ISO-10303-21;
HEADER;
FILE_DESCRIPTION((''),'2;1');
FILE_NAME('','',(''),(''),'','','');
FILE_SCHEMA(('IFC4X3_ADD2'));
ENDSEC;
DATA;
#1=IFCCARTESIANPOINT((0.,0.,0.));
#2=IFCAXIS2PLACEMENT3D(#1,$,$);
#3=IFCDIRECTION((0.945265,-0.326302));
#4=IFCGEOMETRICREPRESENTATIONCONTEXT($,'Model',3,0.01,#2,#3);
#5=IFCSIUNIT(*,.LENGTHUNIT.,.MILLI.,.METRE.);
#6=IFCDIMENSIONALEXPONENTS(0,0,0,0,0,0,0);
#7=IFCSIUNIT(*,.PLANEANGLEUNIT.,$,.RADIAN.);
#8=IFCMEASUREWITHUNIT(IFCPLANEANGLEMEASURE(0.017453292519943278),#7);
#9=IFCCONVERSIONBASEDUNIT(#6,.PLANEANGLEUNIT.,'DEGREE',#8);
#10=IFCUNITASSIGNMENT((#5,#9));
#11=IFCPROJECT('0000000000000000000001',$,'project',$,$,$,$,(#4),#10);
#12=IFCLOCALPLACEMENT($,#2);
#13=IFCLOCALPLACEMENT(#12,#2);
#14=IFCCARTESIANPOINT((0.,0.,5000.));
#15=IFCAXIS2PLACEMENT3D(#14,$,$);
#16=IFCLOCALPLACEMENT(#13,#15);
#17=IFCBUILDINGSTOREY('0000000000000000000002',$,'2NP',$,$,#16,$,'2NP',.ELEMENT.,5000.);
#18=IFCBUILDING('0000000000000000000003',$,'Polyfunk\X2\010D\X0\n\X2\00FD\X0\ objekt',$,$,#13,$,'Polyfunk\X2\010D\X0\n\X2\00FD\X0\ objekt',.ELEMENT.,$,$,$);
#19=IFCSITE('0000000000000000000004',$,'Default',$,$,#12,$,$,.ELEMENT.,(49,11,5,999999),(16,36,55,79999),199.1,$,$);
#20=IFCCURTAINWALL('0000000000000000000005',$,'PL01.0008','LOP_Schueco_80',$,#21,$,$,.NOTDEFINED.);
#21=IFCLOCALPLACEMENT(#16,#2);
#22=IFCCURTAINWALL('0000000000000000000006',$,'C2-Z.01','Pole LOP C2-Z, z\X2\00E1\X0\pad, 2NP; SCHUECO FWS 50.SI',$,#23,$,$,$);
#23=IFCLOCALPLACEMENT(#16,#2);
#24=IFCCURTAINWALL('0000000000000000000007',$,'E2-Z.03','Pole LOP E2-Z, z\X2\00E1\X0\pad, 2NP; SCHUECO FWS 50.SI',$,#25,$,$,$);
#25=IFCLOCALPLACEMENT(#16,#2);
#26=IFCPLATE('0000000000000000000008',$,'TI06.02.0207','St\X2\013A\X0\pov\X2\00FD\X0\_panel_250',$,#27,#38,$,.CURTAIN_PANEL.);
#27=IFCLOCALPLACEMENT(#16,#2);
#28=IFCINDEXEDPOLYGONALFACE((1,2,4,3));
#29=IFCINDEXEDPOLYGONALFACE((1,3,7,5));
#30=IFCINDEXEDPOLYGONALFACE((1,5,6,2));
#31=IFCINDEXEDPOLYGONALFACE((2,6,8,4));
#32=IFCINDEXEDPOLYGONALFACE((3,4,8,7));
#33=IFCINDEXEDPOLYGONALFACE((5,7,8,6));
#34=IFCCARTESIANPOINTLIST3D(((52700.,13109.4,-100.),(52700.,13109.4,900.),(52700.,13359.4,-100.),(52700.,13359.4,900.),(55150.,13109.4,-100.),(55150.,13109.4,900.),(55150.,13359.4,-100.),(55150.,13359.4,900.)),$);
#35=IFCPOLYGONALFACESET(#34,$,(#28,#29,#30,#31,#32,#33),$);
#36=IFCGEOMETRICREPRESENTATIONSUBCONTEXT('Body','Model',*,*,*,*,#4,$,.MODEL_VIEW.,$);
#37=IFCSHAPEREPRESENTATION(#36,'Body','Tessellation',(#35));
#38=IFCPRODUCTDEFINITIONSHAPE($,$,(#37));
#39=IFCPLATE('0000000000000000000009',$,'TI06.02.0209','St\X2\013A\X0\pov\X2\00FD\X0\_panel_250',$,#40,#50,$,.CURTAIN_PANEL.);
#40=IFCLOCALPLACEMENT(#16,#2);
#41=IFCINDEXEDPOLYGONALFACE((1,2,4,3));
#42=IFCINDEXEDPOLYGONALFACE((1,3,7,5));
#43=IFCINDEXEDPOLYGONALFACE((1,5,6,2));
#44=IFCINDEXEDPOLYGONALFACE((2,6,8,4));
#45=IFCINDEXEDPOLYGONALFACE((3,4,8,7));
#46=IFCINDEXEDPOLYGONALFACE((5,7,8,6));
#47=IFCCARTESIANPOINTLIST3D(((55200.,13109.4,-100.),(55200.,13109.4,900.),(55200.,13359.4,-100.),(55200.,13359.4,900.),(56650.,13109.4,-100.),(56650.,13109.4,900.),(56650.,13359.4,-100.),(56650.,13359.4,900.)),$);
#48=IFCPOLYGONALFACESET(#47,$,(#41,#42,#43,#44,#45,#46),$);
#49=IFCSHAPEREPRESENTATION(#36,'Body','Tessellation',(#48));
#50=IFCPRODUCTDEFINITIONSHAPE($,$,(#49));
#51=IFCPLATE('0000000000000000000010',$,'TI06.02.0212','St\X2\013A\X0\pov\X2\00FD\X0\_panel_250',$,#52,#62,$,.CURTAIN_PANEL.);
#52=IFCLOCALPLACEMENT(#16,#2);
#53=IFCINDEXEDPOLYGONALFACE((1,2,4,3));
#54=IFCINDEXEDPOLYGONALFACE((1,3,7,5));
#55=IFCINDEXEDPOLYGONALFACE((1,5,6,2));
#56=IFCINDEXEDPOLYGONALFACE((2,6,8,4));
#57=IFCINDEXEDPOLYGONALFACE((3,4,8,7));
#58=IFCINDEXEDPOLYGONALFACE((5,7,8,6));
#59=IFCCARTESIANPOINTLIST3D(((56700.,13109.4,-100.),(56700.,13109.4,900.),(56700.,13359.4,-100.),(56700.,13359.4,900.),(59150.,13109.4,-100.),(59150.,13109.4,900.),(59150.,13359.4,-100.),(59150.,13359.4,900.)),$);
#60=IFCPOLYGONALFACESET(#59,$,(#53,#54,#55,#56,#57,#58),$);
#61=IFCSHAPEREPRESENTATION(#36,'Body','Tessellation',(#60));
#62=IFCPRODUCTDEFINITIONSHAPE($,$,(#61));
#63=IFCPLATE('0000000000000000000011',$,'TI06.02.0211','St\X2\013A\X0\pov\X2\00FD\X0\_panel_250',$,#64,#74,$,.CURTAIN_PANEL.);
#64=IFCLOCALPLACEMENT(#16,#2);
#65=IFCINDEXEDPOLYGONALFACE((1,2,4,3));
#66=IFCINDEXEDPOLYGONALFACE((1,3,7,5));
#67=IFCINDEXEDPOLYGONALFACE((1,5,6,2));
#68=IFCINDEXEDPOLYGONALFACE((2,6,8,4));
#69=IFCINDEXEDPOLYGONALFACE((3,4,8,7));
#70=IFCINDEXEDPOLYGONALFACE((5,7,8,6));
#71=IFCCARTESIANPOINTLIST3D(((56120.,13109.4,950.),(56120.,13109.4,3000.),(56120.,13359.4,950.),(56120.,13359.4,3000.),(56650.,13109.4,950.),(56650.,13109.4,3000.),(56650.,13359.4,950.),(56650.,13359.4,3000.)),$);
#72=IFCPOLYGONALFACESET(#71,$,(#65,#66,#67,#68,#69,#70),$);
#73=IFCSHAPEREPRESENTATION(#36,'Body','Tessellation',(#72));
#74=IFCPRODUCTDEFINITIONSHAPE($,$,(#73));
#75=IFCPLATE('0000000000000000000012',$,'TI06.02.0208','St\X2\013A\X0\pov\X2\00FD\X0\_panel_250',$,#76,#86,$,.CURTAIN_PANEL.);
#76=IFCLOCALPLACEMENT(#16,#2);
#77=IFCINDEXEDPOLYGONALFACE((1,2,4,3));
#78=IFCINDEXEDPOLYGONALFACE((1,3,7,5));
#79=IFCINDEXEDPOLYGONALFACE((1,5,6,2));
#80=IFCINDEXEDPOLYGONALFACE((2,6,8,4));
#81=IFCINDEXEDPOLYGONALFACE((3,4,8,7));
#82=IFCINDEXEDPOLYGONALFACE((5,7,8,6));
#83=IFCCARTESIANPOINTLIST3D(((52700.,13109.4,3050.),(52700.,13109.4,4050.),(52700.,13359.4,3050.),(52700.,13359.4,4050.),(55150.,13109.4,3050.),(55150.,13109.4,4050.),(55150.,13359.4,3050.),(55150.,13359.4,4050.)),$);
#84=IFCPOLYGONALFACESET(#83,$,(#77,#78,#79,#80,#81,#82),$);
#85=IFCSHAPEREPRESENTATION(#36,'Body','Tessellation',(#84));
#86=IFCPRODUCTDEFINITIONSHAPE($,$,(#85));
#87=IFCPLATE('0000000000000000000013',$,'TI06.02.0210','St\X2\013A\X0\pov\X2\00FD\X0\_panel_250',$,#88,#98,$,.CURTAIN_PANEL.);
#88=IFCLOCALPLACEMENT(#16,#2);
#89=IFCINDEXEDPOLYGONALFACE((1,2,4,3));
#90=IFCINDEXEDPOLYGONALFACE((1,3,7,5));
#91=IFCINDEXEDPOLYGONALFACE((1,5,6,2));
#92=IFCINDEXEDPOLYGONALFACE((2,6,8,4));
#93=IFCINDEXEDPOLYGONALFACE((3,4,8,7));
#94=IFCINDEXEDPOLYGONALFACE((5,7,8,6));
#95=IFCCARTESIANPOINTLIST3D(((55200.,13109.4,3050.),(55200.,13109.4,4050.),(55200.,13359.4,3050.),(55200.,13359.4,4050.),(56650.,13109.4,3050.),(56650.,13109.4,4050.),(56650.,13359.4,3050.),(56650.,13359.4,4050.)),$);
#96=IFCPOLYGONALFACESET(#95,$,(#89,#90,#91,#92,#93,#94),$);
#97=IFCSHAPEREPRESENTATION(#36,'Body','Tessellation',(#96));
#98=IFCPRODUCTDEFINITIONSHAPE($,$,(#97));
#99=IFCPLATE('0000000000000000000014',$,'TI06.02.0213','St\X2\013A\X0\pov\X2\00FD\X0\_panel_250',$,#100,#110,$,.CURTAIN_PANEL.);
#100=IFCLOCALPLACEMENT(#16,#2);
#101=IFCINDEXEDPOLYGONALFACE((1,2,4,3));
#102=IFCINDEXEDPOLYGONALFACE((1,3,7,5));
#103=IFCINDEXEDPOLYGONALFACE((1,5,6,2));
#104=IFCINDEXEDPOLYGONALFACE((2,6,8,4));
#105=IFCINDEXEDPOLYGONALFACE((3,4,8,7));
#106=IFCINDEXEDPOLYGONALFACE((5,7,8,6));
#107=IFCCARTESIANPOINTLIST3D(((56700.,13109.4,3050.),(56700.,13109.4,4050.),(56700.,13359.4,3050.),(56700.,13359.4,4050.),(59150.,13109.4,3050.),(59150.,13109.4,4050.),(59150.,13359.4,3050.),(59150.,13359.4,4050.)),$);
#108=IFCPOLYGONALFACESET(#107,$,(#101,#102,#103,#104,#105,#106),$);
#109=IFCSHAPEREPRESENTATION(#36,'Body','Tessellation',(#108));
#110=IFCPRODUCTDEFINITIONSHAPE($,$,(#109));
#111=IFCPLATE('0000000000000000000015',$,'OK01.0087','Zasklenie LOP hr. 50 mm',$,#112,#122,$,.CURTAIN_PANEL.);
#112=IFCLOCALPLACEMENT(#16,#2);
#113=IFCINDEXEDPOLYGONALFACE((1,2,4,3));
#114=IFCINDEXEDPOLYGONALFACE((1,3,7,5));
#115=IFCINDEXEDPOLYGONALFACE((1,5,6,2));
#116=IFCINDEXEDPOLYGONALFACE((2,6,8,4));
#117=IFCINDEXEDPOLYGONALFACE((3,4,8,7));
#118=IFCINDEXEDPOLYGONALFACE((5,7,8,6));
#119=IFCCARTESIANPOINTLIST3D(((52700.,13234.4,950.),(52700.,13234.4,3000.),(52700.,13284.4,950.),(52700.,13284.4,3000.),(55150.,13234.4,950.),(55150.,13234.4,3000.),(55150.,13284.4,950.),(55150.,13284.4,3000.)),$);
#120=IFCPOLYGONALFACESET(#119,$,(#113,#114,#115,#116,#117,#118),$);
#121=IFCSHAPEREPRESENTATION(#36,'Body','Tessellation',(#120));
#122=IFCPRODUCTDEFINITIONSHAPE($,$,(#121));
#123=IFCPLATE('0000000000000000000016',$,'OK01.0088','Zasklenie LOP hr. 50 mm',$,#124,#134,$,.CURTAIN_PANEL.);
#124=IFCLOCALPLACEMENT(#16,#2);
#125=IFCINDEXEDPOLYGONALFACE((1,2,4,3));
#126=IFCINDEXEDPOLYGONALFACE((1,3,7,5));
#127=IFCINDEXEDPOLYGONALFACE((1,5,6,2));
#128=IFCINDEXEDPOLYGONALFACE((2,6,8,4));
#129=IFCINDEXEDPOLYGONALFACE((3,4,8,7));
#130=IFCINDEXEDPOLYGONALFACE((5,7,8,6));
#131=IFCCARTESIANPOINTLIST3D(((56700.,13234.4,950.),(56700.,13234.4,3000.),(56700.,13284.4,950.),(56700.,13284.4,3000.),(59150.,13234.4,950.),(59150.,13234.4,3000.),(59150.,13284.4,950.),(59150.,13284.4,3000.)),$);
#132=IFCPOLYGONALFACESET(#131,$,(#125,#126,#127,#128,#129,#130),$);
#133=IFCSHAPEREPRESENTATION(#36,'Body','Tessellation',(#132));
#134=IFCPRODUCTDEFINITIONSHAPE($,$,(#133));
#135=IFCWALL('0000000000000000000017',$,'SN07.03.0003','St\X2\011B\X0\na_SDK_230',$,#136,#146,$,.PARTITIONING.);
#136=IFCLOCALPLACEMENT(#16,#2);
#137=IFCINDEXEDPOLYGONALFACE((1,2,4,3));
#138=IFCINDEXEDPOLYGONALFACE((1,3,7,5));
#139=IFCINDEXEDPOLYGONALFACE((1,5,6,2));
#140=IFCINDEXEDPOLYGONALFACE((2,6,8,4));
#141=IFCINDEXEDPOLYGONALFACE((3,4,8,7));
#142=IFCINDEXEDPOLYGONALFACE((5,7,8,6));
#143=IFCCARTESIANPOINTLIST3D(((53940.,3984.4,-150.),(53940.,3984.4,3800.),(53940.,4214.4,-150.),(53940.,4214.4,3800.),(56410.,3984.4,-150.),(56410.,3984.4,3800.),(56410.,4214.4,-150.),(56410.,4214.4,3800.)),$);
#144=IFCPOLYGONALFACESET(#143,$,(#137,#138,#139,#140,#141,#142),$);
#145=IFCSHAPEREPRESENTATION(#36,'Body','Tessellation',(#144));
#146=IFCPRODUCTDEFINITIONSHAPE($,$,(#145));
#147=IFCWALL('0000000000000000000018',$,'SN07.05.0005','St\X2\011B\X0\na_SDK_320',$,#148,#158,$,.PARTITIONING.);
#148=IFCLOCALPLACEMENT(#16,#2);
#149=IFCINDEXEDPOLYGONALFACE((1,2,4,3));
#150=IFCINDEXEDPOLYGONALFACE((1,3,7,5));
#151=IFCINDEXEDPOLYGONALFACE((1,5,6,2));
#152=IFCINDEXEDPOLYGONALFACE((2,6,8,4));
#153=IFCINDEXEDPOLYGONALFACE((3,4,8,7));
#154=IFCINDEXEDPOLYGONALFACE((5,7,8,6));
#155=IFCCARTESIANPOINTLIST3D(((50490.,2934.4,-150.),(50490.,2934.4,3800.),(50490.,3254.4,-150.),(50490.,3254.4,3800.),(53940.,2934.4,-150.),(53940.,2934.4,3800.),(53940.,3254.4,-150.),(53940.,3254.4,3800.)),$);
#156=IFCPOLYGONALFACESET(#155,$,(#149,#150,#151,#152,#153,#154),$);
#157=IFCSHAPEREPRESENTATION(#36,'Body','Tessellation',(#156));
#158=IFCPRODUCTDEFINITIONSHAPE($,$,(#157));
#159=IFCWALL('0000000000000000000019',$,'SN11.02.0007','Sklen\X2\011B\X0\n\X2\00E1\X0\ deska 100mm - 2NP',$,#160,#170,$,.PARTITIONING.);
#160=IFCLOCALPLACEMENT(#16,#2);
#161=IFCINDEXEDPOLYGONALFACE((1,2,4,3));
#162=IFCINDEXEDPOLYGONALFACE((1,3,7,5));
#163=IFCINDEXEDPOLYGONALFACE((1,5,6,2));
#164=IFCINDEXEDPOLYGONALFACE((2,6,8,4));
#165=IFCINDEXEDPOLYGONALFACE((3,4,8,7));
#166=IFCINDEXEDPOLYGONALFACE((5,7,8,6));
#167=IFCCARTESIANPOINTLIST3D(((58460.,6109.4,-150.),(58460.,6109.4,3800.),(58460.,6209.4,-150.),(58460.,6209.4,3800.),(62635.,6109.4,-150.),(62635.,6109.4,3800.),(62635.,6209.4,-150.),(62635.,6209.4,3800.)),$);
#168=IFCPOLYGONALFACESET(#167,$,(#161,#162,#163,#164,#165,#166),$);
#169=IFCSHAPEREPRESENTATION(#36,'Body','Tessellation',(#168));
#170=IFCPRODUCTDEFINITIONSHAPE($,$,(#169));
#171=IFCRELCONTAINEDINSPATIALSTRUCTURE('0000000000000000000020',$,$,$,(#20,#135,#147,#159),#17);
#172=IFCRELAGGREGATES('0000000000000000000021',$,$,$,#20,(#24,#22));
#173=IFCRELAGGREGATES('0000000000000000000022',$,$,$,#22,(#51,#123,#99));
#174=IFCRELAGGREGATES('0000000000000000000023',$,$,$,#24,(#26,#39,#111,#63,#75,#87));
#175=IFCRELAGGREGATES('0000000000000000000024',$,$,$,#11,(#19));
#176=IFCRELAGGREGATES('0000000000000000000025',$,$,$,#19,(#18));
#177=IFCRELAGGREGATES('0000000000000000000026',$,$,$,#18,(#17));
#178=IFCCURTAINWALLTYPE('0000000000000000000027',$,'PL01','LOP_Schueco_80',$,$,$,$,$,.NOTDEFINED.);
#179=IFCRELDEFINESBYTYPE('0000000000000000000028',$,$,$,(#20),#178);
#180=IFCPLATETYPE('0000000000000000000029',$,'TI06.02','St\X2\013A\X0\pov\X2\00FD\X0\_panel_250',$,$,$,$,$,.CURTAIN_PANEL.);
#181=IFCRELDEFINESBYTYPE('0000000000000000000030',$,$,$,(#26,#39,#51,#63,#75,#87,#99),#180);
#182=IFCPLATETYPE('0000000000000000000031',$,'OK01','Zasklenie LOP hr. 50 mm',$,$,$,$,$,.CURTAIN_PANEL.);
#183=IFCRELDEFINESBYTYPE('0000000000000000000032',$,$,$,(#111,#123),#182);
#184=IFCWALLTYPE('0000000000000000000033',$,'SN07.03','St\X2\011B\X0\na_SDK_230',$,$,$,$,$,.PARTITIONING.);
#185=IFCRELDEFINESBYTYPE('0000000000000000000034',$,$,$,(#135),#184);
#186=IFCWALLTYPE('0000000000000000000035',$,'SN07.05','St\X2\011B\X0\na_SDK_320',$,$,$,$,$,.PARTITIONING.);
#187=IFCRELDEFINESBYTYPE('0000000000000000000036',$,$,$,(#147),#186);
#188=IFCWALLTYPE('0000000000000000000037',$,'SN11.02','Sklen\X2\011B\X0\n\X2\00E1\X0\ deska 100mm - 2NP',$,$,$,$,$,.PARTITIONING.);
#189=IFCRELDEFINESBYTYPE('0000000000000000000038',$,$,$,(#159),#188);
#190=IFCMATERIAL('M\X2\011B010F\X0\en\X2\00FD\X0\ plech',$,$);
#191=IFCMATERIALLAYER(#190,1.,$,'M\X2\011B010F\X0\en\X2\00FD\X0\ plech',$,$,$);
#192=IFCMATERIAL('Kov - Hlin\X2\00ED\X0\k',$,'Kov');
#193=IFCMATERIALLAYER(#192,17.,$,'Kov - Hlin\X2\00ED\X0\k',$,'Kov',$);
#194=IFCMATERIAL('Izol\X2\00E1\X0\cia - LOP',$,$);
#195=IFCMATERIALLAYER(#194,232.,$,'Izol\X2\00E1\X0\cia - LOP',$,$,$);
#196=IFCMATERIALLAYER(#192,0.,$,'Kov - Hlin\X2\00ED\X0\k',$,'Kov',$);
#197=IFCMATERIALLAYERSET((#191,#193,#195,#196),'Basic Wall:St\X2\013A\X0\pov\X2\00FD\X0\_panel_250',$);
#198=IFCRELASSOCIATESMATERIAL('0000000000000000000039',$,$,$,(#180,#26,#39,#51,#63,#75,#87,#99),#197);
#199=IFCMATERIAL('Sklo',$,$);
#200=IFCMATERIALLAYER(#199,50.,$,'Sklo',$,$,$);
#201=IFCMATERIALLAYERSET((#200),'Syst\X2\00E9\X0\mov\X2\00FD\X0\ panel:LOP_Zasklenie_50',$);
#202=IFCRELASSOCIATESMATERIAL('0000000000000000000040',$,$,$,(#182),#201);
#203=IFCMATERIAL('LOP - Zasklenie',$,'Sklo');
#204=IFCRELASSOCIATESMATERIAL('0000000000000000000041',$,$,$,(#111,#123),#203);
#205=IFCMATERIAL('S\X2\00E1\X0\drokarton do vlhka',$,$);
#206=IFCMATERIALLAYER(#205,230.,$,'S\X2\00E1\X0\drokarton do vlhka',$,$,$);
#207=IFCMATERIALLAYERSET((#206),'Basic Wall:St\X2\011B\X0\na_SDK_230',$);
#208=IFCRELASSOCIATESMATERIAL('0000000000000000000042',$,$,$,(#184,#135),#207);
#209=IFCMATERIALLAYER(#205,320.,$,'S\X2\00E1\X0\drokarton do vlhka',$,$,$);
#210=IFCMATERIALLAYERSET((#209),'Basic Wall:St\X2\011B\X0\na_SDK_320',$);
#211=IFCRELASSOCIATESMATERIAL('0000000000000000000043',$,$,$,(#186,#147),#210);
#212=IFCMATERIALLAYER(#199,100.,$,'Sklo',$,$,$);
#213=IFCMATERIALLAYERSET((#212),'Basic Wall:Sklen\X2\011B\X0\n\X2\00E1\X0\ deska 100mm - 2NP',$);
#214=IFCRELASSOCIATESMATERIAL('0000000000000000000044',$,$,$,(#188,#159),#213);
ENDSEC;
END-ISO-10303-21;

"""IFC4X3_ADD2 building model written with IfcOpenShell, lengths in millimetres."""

from ifc_helpers import new_model, entity, si_unit, converted_unit, direction, frame, frame_2d, origin, origin_2d_with_axis, place, context, subcontext, project, spatial, polyline, rectangle, extrude, clip, bounded_halfspace, source, transform, mapped, material, layer, layer_set, layer_usage, type_object, type_shapes, element, aggregate, save


model = new_model("IFC4X3_ADD2")

# Units and contexts
model_context = context("Model", 3, precision=0.01, world=origin(), true_north=direction((0.945265, -0.326302)))
body_context = subcontext(model_context, "Body", "Model", "MODEL_VIEW")
ifc_project = project(units=[si_unit("LENGTHUNIT", "METRE", prefix="MILLI"), converted_unit("PLANEANGLEUNIT", "DEGREE", entity("IfcPlaneAngleMeasure", 0.017453292519943278), si_unit("PLANEANGLEUNIT", "RADIAN"), dimensions=[0, 0, 0, 0, 0, 0, 0])], contexts=[model_context])

# Site, building, storey
site_placement = place(None, origin())
site = spatial("IfcSite", under=ifc_project, at=site_placement, Name="Default", CompositionType="ELEMENT", RefLatitude=(49, 11, 5, 999999), RefLongitude=(16, 36, 55, 79999), RefElevation=199.1)
building_placement = place(site_placement, origin())
building = spatial("IfcBuilding", under=site, at=building_placement, Name="Polyfunkčný objekt", LongName="Polyfunkčný objekt", CompositionType="ELEMENT")
storey_placement = place(building_placement, frame((0.0, 0.0, 5000.0)))
storey = spatial("IfcBuildingStorey", under=building, at=storey_placement, Name="2NP", LongName="2NP", CompositionType="ELEMENT", Elevation=5000.0)

# Curtain walls, plates
curtain_wall_type = type_object("IfcCurtainWallType", Name="PL01", Description="LOP_Schueco_80", PredefinedType="NOTDEFINED")
curtain_wall_1_placement = place(storey_placement, frame((0.0, 0.0, -5000.0)))
curtain_wall_1 = element("IfcCurtainWall", 1, at=curtain_wall_1_placement, inside=storey, type_object=curtain_wall_type, Name="PL01.0008", Description="LOP_Schueco_80", PredefinedType="NOTDEFINED")
curtain_wall_2 = element("IfcCurtainWall", 2, Name="C2-Z.01", Description="Pole LOP C2-Z, západ, 2NP; SCHUECO FWS 50.SI")
curtain_wall_3 = element("IfcCurtainWall", 3, Name="E2-Z.03", Description="Pole LOP E2-Z, západ, 2NP; SCHUECO FWS 50.SI")
aggregate(curtain_wall_1, [curtain_wall_3, curtain_wall_2])
ifc_material_1 = material(Name="Měďený plech")
ifc_layer_1 = layer(ifc_material_1, 1.0, Name="Měďený plech")
ifc_material_2 = material(Name="Kov - Hliník", Category="Kov")
ifc_layer_2 = layer(ifc_material_2, 17.0, Name="Kov - Hliník", Category="Kov")
ifc_material_3 = material(Name="Izolácia - LOP")
ifc_layer_3 = layer(ifc_material_3, 232.0, Name="Izolácia - LOP")
ifc_layer_4 = layer(ifc_material_2, 0.0, Name="Kov - Hliník", Category="Kov")
ifc_layer_set_1 = layer_set([ifc_layer_1, ifc_layer_2, ifc_layer_3, ifc_layer_4], Name="Basic Wall:Stĺpový_panel_250")
ifc_layer_usage_1 = layer_usage(ifc_layer_set_1, "AXIS2", "NEGATIVE", 125.0)
plate_type_1 = type_object("IfcPlateType", Name="TI06.02", Description="Stĺpový_panel_250", PredefinedType="CURTAIN_PANEL", material=ifc_layer_set_1)
plate_1_placement = place(storey_placement, frame((52700.0, 13234.4, -100.0)))
plate_1 = element("IfcPlate", 4, at=plate_1_placement, type_object=plate_type_1, material=ifc_layer_usage_1, Name="TI06.02.0207", Description="Stĺpový_panel_250", PredefinedType="CURTAIN_PANEL", context=body_context, shape_type="SweptSolid", body=[
    extrude(rectangle(XDim=250.0, YDim=2450.0, at=origin_2d_with_axis()), frame((1225.0, 0.0, 0.0), z_axis=(0.0, 0.0, 1.0), x_axis=(0.0, 1.0, 0.0)), (0.0, 0.0, 1.0), 1000.0),
])
ifc_layer_usage_2 = layer_usage(ifc_layer_set_1, "AXIS2", "NEGATIVE", 125.0)
plate_2_placement = place(storey_placement, frame((55200.0, 13234.4, -100.0)))
plate_2 = element("IfcPlate", 5, at=plate_2_placement, type_object=plate_type_1, material=ifc_layer_usage_2, Name="TI06.02.0209", Description="Stĺpový_panel_250", PredefinedType="CURTAIN_PANEL", context=body_context, shape_type="SweptSolid", body=[
    extrude(rectangle(XDim=250.0, YDim=1450.0, at=origin_2d_with_axis()), frame((725.0, 0.0, 0.0), z_axis=(0.0, 0.0, 1.0), x_axis=(0.0, 1.0, 0.0)), (0.0, 0.0, 1.0), 1000.0),
])
ifc_layer_usage_3 = layer_usage(ifc_layer_set_1, "AXIS2", "NEGATIVE", 125.0)
plate_3_placement = place(storey_placement, frame((56700.0, 13234.4, -100.0)))
plate_3 = element("IfcPlate", 6, at=plate_3_placement, type_object=plate_type_1, material=ifc_layer_usage_3, Name="TI06.02.0212", Description="Stĺpový_panel_250", PredefinedType="CURTAIN_PANEL", context=body_context, shape_type="SweptSolid", body=[
    extrude(rectangle(XDim=250.0, YDim=2450.0, at=frame_2d((0.0, 0.0), x_axis=(1.0, 0.0))), frame((1225.0, 0.0, 0.0), z_axis=(0.0, 0.0, 1.0), x_axis=(0.0, 1.0, 0.0)), (0.0, 0.0, 1.0), 1000.0),
])
ifc_layer_usage_4 = layer_usage(ifc_layer_set_1, "AXIS2", "NEGATIVE", 125.0)
plate_4_placement = place(storey_placement, frame((56120.0, 13234.4, 950.0)))
plate_4 = element("IfcPlate", 7, at=plate_4_placement, type_object=plate_type_1, material=ifc_layer_usage_4, Name="TI06.02.0211", Description="Stĺpový_panel_250", PredefinedType="CURTAIN_PANEL", context=body_context, shape_type="SweptSolid", body=[
    extrude(rectangle(XDim=250.0, YDim=530.0, at=frame_2d((0.0, 0.0), x_axis=(1.0, 0.0))), frame((265.0, 0.0, 0.0), z_axis=(0.0, 0.0, 1.0), x_axis=(0.0, 1.0, 0.0)), (0.0, 0.0, 1.0), 2050.0),
])
ifc_layer_usage_5 = layer_usage(ifc_layer_set_1, "AXIS2", "NEGATIVE", 125.0)
plate_5_placement = place(storey_placement, frame((52700.0, 13234.4, 3050.0)))
plate_5 = element("IfcPlate", 8, at=plate_5_placement, type_object=plate_type_1, material=ifc_layer_usage_5, Name="TI06.02.0208", Description="Stĺpový_panel_250", PredefinedType="CURTAIN_PANEL", context=body_context, shape_type="SweptSolid", body=[
    extrude(rectangle(XDim=250.0, YDim=2450.0, at=origin_2d_with_axis()), frame((1225.0, 0.0, 0.0), z_axis=(0.0, 0.0, 1.0), x_axis=(0.0, 1.0, 0.0)), (0.0, 0.0, 1.0), 1000.0),
])
ifc_layer_usage_6 = layer_usage(ifc_layer_set_1, "AXIS2", "NEGATIVE", 125.0)
plate_6_placement = place(storey_placement, frame((55200.0, 13234.4, 3050.0)))
plate_6 = element("IfcPlate", 9, at=plate_6_placement, type_object=plate_type_1, material=ifc_layer_usage_6, Name="TI06.02.0210", Description="Stĺpový_panel_250", PredefinedType="CURTAIN_PANEL", context=body_context, shape_type="SweptSolid", body=[
    extrude(rectangle(XDim=250.0, YDim=1450.0, at=origin_2d_with_axis()), frame((725.0, 0.0, 0.0), z_axis=(0.0, 0.0, 1.0), x_axis=(0.0, 1.0, 0.0)), (0.0, 0.0, 1.0), 1000.0),
])
ifc_layer_usage_7 = layer_usage(ifc_layer_set_1, "AXIS2", "NEGATIVE", 125.0)
plate_7_placement = place(storey_placement, frame((56700.0, 13234.4, 3050.0)))
plate_7 = element("IfcPlate", 10, at=plate_7_placement, type_object=plate_type_1, material=ifc_layer_usage_7, Name="TI06.02.0213", Description="Stĺpový_panel_250", PredefinedType="CURTAIN_PANEL", context=body_context, shape_type="SweptSolid", body=[
    extrude(rectangle(XDim=250.0, YDim=2450.0, at=frame_2d((0.0, 0.0), x_axis=(1.0, 0.0))), frame((1225.0, 0.0, 0.0), z_axis=(0.0, 0.0, 1.0), x_axis=(0.0, 1.0, 0.0)), (0.0, 0.0, 1.0), 1000.0),
])
ifc_material_4 = material(Name="LOP - Zasklenie", Category="Sklo")
ifc_material_5 = material(Name="Sklo")
ifc_layer_5 = layer(ifc_material_5, 50.0, Name="Sklo")
ifc_layer_set_2 = layer_set([ifc_layer_5], Name="Systémový panel:LOP_Zasklenie_50")
plate_type_2 = type_object("IfcPlateType", Name="OK01", Description="Zasklenie LOP hr. 50 mm", PredefinedType="CURTAIN_PANEL", material=ifc_layer_set_2)
shared_shape_1 = source(origin(), body_context, "Body", "SweptSolid", [
    extrude(rectangle(XDim=50.0, YDim=2450.0, at=origin_2d_with_axis()), frame((0.0, 25.0, 0.0), z_axis=(0.0, 0.0, 1.0), x_axis=(0.0, 1.0, 0.0)), (0.0, 0.0, 1.0), 2050.0),
])
type_shapes(plate_type_2, [shared_shape_1])
plate_8_placement = place(curtain_wall_1_placement, frame((53925.0, 13234.4, 5950.0)))
plate_8 = element("IfcPlate", 11, at=plate_8_placement, type_object=plate_type_2, material=ifc_material_4, Name="OK01.0087", Description="Zasklenie LOP hr. 50 mm", PredefinedType="CURTAIN_PANEL", context=body_context, shape_type="MappedRepresentation", body=[
    mapped(shared_shape_1, transform((0.0, 0.0, 0.0), scale=1.0)),
])
plate_9_placement = place(curtain_wall_1_placement, frame((57925.0, 13234.4, 5950.0)))
plate_9 = element("IfcPlate", 12, at=plate_9_placement, type_object=plate_type_2, material=ifc_material_4, Name="OK01.0088", Description="Zasklenie LOP hr. 50 mm", PredefinedType="CURTAIN_PANEL", context=body_context, shape_type="MappedRepresentation", body=[
    mapped(shared_shape_1, transform((0.0, 0.0, 0.0), scale=1.0)),
])
aggregate(curtain_wall_2, [plate_3, plate_9, plate_7])

# Walls
ifc_material_6 = material(Name="Sádrokarton do vlhka")
ifc_layer_6 = layer(ifc_material_6, 230.0, Name="Sádrokarton do vlhka")
ifc_layer_set_3 = layer_set([ifc_layer_6], Name="Basic Wall:Stěna_SDK_230")
wall_type_1 = type_object("IfcWallType", Name="SN07.03", Description="Stěna_SDK_230", PredefinedType="PARTITIONING", material=ifc_layer_set_3)
wall_1_placement = place(storey_placement, frame((56410.0, 4099.4, -150.0), z_axis=(0.0, 0.0, 1.0), x_axis=(-1.0, 0.0, 0.0)))
element("IfcWall", 13, at=wall_1_placement, inside=storey, type_object=wall_type_1, material=ifc_layer_set_3, Name="SN07.03.0003", Description="Stěna_SDK_230", PredefinedType="PARTITIONING", context=body_context, shape_type="Clipping", body=[
    clip(clip(extrude(rectangle(XDim=2470.0, YDim=230.0, at=frame_2d((1235.0, 0.0), x_axis=(-1.0, 0.0))), origin(), (0.0, 0.0, 1.0), 3950.0), bounded_halfspace(frame((2470.0, -115.0, 0.0)), True, frame((2470.0, -115.0, 0.0)), polyline([(0.0, 0.0), (0.0, 60.0), (0.0, 230.0), (-320.0, 230.0), (-2470.0, 230.0), (-2470.0, 0.0), (-150.0, 0.0), (0.0, 0.0)]))), bounded_halfspace(frame((0.0, -115.0, 3950.0), z_axis=(0.0, 0.0, -1.0), x_axis=(-1.0, 0.0, 0.0)), True, frame((0.0, -115.0, 3950.0)), polyline([(0.0, 0.0), (2320.0, 0.0), (2470.0, 0.0), (2470.0, 60.0), (2470.0, 230.0), (2150.0, 230.0), (0.0, 230.0), (0.0, 0.0)]))),
])
ifc_layer_7 = layer(ifc_material_6, 320.0, Name="Sádrokarton do vlhka")
ifc_layer_set_4 = layer_set([ifc_layer_7], Name="Basic Wall:Stěna_SDK_320")
wall_type_2 = type_object("IfcWallType", Name="SN07.05", Description="Stěna_SDK_320", PredefinedType="PARTITIONING", material=ifc_layer_set_4)
wall_2_placement = place(storey_placement, frame((53940.0, 3094.4, -150.0), z_axis=(0.0, 0.0, 1.0), x_axis=(-1.0, 0.0, 0.0)))
element("IfcWall", 14, at=wall_2_placement, inside=storey, type_object=wall_type_2, material=ifc_layer_set_4, Name="SN07.05.0005", Description="Stěna_SDK_320", PredefinedType="PARTITIONING", context=body_context, shape_type="Clipping", body=[
    clip(clip(extrude(rectangle(XDim=3450.0, YDim=320.0, at=frame_2d((1725.0, 0.0), x_axis=(-1.0, 0.0))), origin(), (0.0, 0.0, 1.0), 3950.0), bounded_halfspace(frame((3450.0, -160.0, 0.0)), True, frame((3450.0, -160.0, 0.0)), polyline([(0.0, 0.0), (0.0, 320.0), (-1650.0, 320.0), (-1800.0, 320.0), (-3450.0, 320.0), (-3450.0, 0.0), (-1800.0, 0.0), (-1650.0, 0.0), (0.0, 0.0)]))), bounded_halfspace(frame((0.0, -160.0, 3950.0), z_axis=(0.0, 0.0, -1.0), x_axis=(-1.0, 0.0, 0.0)), True, frame((0.0, -160.0, 3950.0)), polyline([(0.0, 0.0), (1650.0, 0.0), (1800.0, 0.0), (3450.0, 0.0), (3450.0, 320.0), (1800.0, 320.0), (1650.0, 320.0), (0.0, 320.0), (0.0, 0.0)]))),
])
ifc_layer_8 = layer(ifc_material_5, 100.0, Name="Sklo")
ifc_layer_set_5 = layer_set([ifc_layer_8], Name="Basic Wall:Skleněná deska 100mm - 2NP")
wall_type_3 = type_object("IfcWallType", Name="SN11.02", Description="Skleněná deska 100mm - 2NP", PredefinedType="PARTITIONING", material=ifc_layer_set_5)
wall_3_placement = place(storey_placement, frame((58460.0, 6159.4, -150.0)))
element("IfcWall", 15, at=wall_3_placement, inside=storey, type_object=wall_type_3, material=ifc_layer_set_5, Name="SN11.02.0007", Description="Skleněná deska 100mm - 2NP", PredefinedType="PARTITIONING", context=body_context, shape_type="Clipping", body=[
    clip(clip(extrude(rectangle(XDim=4175.0, YDim=100.0, at=frame_2d((2087.5, 0.0), x_axis=(-1.0, 0.0))), origin(), (0.0, 0.0, 1.0), 3950.0), bounded_halfspace(frame((4175.0, -50.0, 0.0), z_axis=(0.0, 0.0, 1.0), x_axis=(-1.0, 0.0, 0.0)), True, frame((4175.0, -50.0, 0.0)), polyline([(0.0, 0.0), (0.0, 100.0), (-4175.0, 100.0), (-4175.0, 0.0), (-4075.0, 0.0), (0.0, 0.0)]))), bounded_halfspace(frame((0.0, -50.0, 3950.0), z_axis=(0.0, 0.0, -1.0), x_axis=(1.0, 0.0, 0.0)), True, frame((0.0, -50.0, 3950.0)), polyline([(0.0, 0.0), (100.0, 0.0), (4175.0, 0.0), (4175.0, 100.0), (0.0, 100.0), (0.0, 0.0)]))),
])

aggregate(curtain_wall_3, [plate_1, plate_2, plate_8, plate_4, plate_5, plate_6])

save(model, "model.ifc")
